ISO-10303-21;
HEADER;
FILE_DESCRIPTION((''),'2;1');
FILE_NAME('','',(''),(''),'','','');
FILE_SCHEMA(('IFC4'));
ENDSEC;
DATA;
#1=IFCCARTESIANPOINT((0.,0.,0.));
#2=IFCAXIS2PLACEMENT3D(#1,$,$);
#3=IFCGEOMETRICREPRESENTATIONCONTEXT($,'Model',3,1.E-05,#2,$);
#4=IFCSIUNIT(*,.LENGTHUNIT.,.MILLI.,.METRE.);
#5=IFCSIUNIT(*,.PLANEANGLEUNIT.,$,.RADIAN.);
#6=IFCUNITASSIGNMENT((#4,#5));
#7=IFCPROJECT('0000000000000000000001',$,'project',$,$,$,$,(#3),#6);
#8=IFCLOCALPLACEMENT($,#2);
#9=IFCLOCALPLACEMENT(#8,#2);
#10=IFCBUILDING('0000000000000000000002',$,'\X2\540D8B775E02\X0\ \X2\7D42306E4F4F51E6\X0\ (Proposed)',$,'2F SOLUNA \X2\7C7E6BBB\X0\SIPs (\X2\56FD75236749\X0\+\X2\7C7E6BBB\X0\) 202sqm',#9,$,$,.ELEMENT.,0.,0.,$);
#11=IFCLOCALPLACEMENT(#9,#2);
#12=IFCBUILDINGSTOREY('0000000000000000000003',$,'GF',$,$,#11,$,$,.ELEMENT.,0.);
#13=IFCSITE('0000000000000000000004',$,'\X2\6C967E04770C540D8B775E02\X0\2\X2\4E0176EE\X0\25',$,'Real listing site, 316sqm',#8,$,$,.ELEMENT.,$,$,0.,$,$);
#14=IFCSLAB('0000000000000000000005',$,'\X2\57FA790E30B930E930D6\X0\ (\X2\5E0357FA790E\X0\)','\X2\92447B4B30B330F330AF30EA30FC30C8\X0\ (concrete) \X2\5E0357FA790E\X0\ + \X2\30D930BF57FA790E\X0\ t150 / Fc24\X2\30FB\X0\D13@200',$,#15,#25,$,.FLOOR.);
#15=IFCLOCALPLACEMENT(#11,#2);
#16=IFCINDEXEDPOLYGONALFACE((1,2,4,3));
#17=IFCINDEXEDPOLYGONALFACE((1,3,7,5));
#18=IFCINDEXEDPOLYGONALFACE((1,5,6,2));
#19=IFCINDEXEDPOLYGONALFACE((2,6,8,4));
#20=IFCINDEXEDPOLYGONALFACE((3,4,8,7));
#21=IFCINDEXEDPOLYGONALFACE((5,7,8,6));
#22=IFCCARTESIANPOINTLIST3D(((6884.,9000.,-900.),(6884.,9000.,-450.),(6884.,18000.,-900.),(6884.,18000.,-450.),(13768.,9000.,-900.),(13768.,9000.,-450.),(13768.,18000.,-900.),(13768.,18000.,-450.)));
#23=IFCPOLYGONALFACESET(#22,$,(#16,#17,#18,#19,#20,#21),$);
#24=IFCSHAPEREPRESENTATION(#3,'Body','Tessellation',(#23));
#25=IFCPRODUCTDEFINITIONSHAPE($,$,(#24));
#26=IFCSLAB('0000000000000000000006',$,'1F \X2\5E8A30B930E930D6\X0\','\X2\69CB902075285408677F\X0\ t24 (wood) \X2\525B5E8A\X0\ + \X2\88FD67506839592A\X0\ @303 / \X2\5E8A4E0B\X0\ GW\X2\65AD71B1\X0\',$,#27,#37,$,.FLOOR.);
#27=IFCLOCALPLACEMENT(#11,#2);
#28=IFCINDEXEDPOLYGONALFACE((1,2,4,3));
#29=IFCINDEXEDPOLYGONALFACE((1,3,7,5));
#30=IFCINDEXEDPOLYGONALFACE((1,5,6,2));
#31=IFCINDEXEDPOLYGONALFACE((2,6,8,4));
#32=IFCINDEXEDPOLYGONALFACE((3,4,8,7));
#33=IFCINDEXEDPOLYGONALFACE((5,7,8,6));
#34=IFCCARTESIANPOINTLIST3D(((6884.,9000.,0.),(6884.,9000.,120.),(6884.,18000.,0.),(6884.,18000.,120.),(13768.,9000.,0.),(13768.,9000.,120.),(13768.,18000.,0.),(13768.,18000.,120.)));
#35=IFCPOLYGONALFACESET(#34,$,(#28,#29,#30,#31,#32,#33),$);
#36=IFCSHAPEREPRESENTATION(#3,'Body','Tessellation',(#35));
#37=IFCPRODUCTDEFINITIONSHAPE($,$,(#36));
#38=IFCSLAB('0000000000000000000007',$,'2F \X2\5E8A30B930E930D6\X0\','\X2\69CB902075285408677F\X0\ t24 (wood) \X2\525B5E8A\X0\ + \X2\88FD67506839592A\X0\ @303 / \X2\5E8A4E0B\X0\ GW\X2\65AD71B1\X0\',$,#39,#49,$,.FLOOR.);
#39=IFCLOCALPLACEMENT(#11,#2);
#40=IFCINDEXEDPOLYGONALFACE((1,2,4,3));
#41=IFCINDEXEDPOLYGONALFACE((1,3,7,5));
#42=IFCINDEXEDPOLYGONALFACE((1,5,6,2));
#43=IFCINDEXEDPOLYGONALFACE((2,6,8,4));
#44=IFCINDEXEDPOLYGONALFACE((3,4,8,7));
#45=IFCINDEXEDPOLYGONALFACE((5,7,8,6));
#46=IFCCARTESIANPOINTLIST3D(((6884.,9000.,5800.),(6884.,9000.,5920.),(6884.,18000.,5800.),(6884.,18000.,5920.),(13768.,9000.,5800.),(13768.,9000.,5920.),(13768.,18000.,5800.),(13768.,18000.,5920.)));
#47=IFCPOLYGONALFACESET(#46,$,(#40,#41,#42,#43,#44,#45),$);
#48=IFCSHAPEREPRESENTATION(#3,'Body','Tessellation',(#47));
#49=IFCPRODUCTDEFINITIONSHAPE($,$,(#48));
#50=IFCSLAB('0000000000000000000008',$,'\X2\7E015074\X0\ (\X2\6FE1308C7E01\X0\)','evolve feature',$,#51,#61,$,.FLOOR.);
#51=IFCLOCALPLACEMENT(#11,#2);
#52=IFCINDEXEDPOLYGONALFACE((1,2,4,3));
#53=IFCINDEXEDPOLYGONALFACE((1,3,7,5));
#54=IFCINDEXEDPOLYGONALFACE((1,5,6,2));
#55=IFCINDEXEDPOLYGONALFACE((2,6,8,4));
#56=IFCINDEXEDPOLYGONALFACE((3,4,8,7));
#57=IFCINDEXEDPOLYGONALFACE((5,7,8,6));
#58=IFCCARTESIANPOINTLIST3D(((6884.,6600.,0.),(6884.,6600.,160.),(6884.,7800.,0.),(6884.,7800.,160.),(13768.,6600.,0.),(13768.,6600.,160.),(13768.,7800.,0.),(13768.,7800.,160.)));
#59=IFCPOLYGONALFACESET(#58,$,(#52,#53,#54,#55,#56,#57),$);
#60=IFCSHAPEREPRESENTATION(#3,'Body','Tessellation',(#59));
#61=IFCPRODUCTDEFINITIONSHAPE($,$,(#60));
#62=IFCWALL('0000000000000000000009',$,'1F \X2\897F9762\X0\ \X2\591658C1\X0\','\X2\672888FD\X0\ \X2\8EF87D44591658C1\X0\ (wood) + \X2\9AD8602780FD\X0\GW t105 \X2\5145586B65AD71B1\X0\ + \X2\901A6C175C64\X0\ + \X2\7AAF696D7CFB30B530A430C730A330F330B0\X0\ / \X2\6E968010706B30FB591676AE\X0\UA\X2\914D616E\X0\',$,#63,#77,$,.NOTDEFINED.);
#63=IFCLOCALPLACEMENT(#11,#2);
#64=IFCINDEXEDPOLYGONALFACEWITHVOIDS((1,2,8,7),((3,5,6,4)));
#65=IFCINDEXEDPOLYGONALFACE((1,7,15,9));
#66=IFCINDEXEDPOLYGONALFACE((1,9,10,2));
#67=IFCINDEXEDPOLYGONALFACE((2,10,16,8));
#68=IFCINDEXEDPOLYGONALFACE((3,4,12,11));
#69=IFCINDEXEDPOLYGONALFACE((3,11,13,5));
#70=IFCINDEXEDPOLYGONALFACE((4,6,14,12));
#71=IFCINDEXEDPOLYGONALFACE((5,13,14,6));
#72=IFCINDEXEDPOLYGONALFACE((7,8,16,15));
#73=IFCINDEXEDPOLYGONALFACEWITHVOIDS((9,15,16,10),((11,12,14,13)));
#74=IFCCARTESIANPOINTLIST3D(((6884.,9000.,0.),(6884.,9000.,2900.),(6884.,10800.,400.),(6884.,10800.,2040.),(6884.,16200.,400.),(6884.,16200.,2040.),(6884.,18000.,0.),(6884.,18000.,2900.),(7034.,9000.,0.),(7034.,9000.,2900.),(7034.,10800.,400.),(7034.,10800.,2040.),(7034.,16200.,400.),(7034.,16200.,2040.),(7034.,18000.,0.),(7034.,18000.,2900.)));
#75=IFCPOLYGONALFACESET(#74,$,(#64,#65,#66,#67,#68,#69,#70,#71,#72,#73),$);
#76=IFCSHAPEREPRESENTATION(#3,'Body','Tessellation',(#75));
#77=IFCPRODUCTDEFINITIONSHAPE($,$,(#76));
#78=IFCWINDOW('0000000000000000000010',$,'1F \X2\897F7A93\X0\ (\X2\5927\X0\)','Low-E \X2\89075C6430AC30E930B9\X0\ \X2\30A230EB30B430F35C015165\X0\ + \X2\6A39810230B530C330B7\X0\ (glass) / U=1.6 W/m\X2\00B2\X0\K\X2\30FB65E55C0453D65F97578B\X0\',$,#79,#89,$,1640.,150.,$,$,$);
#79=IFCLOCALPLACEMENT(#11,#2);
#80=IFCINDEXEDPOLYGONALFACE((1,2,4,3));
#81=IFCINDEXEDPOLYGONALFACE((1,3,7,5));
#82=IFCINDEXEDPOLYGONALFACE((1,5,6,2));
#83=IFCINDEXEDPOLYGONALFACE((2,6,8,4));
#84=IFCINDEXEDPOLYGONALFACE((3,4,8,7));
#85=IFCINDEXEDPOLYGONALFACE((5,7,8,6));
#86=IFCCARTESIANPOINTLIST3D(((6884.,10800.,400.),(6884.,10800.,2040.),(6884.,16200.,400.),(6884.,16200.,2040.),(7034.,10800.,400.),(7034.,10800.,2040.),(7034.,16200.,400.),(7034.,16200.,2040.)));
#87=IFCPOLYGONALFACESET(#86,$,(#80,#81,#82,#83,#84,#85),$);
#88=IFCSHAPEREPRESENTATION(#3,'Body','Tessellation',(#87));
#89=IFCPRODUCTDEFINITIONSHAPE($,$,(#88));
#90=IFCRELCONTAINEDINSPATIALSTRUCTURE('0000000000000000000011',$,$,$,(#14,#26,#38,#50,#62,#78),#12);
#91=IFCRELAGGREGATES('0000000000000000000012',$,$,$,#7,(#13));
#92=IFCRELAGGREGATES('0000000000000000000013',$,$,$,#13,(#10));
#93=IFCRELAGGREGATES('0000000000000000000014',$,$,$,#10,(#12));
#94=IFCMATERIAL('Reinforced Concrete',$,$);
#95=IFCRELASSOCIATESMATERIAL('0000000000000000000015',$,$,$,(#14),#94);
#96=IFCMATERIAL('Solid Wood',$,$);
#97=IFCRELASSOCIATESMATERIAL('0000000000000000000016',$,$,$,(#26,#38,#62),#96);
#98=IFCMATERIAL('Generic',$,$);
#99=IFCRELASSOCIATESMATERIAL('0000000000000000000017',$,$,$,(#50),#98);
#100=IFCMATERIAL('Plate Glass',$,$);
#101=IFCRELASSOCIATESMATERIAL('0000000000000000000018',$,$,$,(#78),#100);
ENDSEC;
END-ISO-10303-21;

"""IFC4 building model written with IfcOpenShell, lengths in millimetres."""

from ifc_helpers import new_model, si_unit, frame, frame_2d, origin, place, context, project, spatial, rectangle, extrude, material, element, fill, save


model = new_model("IFC4")

# Units and contexts
model_context = context("Model", 3, precision=1e-05, world=origin())
ifc_project = project(units=[si_unit("LENGTHUNIT", "METRE", prefix="MILLI"), si_unit("PLANEANGLEUNIT", "RADIAN")], contexts=[model_context])

# Site, building, storey
site_placement = place(None, origin())
site = spatial("IfcSite", under=ifc_project, at=site_placement, Name="沖縄県名護市2丁目25", ObjectType="Real listing site, 316sqm", CompositionType="ELEMENT", RefElevation=0.0)
building_placement = place(site_placement, origin())
building = spatial("IfcBuilding", under=site, at=building_placement, Name="名護市 終の住処 (Proposed)", ObjectType="2F SOLUNA 籾殻SIPs (国産杉+籾殻) 202sqm", CompositionType="ELEMENT", ElevationOfRefHeight=0.0, ElevationOfTerrain=0.0)
storey_placement = place(building_placement, origin())
storey = spatial("IfcBuildingStorey", under=building, at=storey_placement, Name="GF", CompositionType="ELEMENT", Elevation=0.0)

# Slabs
ifc_material_1 = material(Name="Reinforced Concrete")
slab_1_placement = place(storey_placement, frame((3442.0, 4500.0, -450.0)))
element("IfcSlab", 1, at=slab_1_placement, inside=storey, material=ifc_material_1, Name="基礎スラブ (布基礎)", Description="鉄筋コンクリート (concrete) 布基礎 + ベタ基礎 t150 / Fc24・D13@200", PredefinedType="FLOOR", context=model_context, shape_type="SweptSolid", body=[
    extrude(rectangle(XDim=6884.0, YDim=9000.0, at=frame_2d((3442.0, 4500.0))), frame((3442.0, 4500.0, -450.0)), (0.0, 0.0, 1.0), 450.0),
])
ifc_material_2 = material(Name="Solid Wood")
slab_2_placement = place(storey_placement, frame((3442.0, 4500.0, 0.0)))
element("IfcSlab", 2, at=slab_2_placement, inside=storey, material=ifc_material_2, Name="1F 床スラブ", Description="構造用合板 t24 (wood) 剛床 + 製材根太 @303 / 床下 GW断熱", PredefinedType="FLOOR", context=model_context, shape_type="SweptSolid", body=[
    extrude(rectangle(XDim=6884.0, YDim=9000.0, at=frame_2d((3442.0, 4500.0))), frame((3442.0, 4500.0, 0.0)), (0.0, 0.0, 1.0), 120.0),
])
slab_3_placement = place(storey_placement, frame((3442.0, 4500.0, 2900.0)))
element("IfcSlab", 3, at=slab_3_placement, inside=storey, material=ifc_material_2, Name="2F 床スラブ", Description="構造用合板 t24 (wood) 剛床 + 製材根太 @303 / 床下 GW断熱", PredefinedType="FLOOR", context=model_context, shape_type="SweptSolid", body=[
    extrude(rectangle(XDim=6884.0, YDim=9000.0, at=frame_2d((3442.0, 4500.0))), frame((3442.0, 4500.0, 2900.0)), (0.0, 0.0, 1.0), 120.0),
])
ifc_material_3 = material(Name="Generic")
slab_4_placement = place(storey_placement, frame((3442.0, 3300.0, 0.0)))
element("IfcSlab", 4, at=slab_4_placement, inside=storey, material=ifc_material_3, Name="縁側 (濡れ縁)", Description="evolve feature", PredefinedType="FLOOR", context=model_context, shape_type="SweptSolid", body=[
    extrude(rectangle(XDim=6884.0, YDim=1200.0, at=frame_2d((3442.0, 600.0))), frame((3442.0, 3300.0, 0.0)), (0.0, 0.0, 1.0), 160.0),
])

# Shared definitions
ifc_material_4 = material(Name="Plate Glass")

# Wall, opening, window
wall_1_placement = place(storey_placement, frame((3442.0, 4500.0, 0.0)))
wall_1 = element("IfcWall", 5, at=wall_1_placement, inside=storey, material=ifc_material_2, Name="1F 西面 外壁", Description="木製 軸組外壁 (wood) + 高性能GW t105 充填断熱 + 通気層 + 窯業系サイディング / 準耐火・外皮UA配慮", PredefinedType="NOTDEFINED", context=model_context, shape_type="SweptSolid", body=[
    extrude(rectangle(XDim=150.0, YDim=9000.0, at=frame_2d((75.0, 4500.0))), frame((3442.0, 4500.0, 0.0)), (0.0, 0.0, 1.0), 2900.0),
])
opening_1_placement = place(storey_placement, frame((3442.0, 5400.0, 200.0)))
opening_1 = element("IfcOpeningElement", 6, at=opening_1_placement, cuts=wall_1, PredefinedType="NOTDEFINED", context=model_context, shape_type="SweptSolid", body=[
    extrude(rectangle(XDim=150.0, YDim=5400.0, at=frame_2d((75.0, 2700.0))), frame((3442.0, 5400.0, 200.0)), (0.0, 0.0, 1.0), 1640.0),
])
window_1_placement = place(storey_placement, frame((3442.0, 5400.0, 200.0)))
window_1 = element("IfcWindow", 7, at=window_1_placement, inside=storey, material=ifc_material_4, Name="1F 西窓 (大)", Description="Low-E 複層ガラス アルゴン封入 + 樹脂サッシ (glass) / U=1.6 W/m²K・日射取得型", OverallHeight=1640.0, OverallWidth=150.0, context=model_context, shape_type="SweptSolid", body=[
    extrude(rectangle(XDim=150.0, YDim=5400.0, at=frame_2d((75.0, 2700.0))), frame((3442.0, 5400.0, 200.0)), (0.0, 0.0, 1.0), 1640.0),
])
fill(opening_1, window_1)

save(model, "model.ifc")
